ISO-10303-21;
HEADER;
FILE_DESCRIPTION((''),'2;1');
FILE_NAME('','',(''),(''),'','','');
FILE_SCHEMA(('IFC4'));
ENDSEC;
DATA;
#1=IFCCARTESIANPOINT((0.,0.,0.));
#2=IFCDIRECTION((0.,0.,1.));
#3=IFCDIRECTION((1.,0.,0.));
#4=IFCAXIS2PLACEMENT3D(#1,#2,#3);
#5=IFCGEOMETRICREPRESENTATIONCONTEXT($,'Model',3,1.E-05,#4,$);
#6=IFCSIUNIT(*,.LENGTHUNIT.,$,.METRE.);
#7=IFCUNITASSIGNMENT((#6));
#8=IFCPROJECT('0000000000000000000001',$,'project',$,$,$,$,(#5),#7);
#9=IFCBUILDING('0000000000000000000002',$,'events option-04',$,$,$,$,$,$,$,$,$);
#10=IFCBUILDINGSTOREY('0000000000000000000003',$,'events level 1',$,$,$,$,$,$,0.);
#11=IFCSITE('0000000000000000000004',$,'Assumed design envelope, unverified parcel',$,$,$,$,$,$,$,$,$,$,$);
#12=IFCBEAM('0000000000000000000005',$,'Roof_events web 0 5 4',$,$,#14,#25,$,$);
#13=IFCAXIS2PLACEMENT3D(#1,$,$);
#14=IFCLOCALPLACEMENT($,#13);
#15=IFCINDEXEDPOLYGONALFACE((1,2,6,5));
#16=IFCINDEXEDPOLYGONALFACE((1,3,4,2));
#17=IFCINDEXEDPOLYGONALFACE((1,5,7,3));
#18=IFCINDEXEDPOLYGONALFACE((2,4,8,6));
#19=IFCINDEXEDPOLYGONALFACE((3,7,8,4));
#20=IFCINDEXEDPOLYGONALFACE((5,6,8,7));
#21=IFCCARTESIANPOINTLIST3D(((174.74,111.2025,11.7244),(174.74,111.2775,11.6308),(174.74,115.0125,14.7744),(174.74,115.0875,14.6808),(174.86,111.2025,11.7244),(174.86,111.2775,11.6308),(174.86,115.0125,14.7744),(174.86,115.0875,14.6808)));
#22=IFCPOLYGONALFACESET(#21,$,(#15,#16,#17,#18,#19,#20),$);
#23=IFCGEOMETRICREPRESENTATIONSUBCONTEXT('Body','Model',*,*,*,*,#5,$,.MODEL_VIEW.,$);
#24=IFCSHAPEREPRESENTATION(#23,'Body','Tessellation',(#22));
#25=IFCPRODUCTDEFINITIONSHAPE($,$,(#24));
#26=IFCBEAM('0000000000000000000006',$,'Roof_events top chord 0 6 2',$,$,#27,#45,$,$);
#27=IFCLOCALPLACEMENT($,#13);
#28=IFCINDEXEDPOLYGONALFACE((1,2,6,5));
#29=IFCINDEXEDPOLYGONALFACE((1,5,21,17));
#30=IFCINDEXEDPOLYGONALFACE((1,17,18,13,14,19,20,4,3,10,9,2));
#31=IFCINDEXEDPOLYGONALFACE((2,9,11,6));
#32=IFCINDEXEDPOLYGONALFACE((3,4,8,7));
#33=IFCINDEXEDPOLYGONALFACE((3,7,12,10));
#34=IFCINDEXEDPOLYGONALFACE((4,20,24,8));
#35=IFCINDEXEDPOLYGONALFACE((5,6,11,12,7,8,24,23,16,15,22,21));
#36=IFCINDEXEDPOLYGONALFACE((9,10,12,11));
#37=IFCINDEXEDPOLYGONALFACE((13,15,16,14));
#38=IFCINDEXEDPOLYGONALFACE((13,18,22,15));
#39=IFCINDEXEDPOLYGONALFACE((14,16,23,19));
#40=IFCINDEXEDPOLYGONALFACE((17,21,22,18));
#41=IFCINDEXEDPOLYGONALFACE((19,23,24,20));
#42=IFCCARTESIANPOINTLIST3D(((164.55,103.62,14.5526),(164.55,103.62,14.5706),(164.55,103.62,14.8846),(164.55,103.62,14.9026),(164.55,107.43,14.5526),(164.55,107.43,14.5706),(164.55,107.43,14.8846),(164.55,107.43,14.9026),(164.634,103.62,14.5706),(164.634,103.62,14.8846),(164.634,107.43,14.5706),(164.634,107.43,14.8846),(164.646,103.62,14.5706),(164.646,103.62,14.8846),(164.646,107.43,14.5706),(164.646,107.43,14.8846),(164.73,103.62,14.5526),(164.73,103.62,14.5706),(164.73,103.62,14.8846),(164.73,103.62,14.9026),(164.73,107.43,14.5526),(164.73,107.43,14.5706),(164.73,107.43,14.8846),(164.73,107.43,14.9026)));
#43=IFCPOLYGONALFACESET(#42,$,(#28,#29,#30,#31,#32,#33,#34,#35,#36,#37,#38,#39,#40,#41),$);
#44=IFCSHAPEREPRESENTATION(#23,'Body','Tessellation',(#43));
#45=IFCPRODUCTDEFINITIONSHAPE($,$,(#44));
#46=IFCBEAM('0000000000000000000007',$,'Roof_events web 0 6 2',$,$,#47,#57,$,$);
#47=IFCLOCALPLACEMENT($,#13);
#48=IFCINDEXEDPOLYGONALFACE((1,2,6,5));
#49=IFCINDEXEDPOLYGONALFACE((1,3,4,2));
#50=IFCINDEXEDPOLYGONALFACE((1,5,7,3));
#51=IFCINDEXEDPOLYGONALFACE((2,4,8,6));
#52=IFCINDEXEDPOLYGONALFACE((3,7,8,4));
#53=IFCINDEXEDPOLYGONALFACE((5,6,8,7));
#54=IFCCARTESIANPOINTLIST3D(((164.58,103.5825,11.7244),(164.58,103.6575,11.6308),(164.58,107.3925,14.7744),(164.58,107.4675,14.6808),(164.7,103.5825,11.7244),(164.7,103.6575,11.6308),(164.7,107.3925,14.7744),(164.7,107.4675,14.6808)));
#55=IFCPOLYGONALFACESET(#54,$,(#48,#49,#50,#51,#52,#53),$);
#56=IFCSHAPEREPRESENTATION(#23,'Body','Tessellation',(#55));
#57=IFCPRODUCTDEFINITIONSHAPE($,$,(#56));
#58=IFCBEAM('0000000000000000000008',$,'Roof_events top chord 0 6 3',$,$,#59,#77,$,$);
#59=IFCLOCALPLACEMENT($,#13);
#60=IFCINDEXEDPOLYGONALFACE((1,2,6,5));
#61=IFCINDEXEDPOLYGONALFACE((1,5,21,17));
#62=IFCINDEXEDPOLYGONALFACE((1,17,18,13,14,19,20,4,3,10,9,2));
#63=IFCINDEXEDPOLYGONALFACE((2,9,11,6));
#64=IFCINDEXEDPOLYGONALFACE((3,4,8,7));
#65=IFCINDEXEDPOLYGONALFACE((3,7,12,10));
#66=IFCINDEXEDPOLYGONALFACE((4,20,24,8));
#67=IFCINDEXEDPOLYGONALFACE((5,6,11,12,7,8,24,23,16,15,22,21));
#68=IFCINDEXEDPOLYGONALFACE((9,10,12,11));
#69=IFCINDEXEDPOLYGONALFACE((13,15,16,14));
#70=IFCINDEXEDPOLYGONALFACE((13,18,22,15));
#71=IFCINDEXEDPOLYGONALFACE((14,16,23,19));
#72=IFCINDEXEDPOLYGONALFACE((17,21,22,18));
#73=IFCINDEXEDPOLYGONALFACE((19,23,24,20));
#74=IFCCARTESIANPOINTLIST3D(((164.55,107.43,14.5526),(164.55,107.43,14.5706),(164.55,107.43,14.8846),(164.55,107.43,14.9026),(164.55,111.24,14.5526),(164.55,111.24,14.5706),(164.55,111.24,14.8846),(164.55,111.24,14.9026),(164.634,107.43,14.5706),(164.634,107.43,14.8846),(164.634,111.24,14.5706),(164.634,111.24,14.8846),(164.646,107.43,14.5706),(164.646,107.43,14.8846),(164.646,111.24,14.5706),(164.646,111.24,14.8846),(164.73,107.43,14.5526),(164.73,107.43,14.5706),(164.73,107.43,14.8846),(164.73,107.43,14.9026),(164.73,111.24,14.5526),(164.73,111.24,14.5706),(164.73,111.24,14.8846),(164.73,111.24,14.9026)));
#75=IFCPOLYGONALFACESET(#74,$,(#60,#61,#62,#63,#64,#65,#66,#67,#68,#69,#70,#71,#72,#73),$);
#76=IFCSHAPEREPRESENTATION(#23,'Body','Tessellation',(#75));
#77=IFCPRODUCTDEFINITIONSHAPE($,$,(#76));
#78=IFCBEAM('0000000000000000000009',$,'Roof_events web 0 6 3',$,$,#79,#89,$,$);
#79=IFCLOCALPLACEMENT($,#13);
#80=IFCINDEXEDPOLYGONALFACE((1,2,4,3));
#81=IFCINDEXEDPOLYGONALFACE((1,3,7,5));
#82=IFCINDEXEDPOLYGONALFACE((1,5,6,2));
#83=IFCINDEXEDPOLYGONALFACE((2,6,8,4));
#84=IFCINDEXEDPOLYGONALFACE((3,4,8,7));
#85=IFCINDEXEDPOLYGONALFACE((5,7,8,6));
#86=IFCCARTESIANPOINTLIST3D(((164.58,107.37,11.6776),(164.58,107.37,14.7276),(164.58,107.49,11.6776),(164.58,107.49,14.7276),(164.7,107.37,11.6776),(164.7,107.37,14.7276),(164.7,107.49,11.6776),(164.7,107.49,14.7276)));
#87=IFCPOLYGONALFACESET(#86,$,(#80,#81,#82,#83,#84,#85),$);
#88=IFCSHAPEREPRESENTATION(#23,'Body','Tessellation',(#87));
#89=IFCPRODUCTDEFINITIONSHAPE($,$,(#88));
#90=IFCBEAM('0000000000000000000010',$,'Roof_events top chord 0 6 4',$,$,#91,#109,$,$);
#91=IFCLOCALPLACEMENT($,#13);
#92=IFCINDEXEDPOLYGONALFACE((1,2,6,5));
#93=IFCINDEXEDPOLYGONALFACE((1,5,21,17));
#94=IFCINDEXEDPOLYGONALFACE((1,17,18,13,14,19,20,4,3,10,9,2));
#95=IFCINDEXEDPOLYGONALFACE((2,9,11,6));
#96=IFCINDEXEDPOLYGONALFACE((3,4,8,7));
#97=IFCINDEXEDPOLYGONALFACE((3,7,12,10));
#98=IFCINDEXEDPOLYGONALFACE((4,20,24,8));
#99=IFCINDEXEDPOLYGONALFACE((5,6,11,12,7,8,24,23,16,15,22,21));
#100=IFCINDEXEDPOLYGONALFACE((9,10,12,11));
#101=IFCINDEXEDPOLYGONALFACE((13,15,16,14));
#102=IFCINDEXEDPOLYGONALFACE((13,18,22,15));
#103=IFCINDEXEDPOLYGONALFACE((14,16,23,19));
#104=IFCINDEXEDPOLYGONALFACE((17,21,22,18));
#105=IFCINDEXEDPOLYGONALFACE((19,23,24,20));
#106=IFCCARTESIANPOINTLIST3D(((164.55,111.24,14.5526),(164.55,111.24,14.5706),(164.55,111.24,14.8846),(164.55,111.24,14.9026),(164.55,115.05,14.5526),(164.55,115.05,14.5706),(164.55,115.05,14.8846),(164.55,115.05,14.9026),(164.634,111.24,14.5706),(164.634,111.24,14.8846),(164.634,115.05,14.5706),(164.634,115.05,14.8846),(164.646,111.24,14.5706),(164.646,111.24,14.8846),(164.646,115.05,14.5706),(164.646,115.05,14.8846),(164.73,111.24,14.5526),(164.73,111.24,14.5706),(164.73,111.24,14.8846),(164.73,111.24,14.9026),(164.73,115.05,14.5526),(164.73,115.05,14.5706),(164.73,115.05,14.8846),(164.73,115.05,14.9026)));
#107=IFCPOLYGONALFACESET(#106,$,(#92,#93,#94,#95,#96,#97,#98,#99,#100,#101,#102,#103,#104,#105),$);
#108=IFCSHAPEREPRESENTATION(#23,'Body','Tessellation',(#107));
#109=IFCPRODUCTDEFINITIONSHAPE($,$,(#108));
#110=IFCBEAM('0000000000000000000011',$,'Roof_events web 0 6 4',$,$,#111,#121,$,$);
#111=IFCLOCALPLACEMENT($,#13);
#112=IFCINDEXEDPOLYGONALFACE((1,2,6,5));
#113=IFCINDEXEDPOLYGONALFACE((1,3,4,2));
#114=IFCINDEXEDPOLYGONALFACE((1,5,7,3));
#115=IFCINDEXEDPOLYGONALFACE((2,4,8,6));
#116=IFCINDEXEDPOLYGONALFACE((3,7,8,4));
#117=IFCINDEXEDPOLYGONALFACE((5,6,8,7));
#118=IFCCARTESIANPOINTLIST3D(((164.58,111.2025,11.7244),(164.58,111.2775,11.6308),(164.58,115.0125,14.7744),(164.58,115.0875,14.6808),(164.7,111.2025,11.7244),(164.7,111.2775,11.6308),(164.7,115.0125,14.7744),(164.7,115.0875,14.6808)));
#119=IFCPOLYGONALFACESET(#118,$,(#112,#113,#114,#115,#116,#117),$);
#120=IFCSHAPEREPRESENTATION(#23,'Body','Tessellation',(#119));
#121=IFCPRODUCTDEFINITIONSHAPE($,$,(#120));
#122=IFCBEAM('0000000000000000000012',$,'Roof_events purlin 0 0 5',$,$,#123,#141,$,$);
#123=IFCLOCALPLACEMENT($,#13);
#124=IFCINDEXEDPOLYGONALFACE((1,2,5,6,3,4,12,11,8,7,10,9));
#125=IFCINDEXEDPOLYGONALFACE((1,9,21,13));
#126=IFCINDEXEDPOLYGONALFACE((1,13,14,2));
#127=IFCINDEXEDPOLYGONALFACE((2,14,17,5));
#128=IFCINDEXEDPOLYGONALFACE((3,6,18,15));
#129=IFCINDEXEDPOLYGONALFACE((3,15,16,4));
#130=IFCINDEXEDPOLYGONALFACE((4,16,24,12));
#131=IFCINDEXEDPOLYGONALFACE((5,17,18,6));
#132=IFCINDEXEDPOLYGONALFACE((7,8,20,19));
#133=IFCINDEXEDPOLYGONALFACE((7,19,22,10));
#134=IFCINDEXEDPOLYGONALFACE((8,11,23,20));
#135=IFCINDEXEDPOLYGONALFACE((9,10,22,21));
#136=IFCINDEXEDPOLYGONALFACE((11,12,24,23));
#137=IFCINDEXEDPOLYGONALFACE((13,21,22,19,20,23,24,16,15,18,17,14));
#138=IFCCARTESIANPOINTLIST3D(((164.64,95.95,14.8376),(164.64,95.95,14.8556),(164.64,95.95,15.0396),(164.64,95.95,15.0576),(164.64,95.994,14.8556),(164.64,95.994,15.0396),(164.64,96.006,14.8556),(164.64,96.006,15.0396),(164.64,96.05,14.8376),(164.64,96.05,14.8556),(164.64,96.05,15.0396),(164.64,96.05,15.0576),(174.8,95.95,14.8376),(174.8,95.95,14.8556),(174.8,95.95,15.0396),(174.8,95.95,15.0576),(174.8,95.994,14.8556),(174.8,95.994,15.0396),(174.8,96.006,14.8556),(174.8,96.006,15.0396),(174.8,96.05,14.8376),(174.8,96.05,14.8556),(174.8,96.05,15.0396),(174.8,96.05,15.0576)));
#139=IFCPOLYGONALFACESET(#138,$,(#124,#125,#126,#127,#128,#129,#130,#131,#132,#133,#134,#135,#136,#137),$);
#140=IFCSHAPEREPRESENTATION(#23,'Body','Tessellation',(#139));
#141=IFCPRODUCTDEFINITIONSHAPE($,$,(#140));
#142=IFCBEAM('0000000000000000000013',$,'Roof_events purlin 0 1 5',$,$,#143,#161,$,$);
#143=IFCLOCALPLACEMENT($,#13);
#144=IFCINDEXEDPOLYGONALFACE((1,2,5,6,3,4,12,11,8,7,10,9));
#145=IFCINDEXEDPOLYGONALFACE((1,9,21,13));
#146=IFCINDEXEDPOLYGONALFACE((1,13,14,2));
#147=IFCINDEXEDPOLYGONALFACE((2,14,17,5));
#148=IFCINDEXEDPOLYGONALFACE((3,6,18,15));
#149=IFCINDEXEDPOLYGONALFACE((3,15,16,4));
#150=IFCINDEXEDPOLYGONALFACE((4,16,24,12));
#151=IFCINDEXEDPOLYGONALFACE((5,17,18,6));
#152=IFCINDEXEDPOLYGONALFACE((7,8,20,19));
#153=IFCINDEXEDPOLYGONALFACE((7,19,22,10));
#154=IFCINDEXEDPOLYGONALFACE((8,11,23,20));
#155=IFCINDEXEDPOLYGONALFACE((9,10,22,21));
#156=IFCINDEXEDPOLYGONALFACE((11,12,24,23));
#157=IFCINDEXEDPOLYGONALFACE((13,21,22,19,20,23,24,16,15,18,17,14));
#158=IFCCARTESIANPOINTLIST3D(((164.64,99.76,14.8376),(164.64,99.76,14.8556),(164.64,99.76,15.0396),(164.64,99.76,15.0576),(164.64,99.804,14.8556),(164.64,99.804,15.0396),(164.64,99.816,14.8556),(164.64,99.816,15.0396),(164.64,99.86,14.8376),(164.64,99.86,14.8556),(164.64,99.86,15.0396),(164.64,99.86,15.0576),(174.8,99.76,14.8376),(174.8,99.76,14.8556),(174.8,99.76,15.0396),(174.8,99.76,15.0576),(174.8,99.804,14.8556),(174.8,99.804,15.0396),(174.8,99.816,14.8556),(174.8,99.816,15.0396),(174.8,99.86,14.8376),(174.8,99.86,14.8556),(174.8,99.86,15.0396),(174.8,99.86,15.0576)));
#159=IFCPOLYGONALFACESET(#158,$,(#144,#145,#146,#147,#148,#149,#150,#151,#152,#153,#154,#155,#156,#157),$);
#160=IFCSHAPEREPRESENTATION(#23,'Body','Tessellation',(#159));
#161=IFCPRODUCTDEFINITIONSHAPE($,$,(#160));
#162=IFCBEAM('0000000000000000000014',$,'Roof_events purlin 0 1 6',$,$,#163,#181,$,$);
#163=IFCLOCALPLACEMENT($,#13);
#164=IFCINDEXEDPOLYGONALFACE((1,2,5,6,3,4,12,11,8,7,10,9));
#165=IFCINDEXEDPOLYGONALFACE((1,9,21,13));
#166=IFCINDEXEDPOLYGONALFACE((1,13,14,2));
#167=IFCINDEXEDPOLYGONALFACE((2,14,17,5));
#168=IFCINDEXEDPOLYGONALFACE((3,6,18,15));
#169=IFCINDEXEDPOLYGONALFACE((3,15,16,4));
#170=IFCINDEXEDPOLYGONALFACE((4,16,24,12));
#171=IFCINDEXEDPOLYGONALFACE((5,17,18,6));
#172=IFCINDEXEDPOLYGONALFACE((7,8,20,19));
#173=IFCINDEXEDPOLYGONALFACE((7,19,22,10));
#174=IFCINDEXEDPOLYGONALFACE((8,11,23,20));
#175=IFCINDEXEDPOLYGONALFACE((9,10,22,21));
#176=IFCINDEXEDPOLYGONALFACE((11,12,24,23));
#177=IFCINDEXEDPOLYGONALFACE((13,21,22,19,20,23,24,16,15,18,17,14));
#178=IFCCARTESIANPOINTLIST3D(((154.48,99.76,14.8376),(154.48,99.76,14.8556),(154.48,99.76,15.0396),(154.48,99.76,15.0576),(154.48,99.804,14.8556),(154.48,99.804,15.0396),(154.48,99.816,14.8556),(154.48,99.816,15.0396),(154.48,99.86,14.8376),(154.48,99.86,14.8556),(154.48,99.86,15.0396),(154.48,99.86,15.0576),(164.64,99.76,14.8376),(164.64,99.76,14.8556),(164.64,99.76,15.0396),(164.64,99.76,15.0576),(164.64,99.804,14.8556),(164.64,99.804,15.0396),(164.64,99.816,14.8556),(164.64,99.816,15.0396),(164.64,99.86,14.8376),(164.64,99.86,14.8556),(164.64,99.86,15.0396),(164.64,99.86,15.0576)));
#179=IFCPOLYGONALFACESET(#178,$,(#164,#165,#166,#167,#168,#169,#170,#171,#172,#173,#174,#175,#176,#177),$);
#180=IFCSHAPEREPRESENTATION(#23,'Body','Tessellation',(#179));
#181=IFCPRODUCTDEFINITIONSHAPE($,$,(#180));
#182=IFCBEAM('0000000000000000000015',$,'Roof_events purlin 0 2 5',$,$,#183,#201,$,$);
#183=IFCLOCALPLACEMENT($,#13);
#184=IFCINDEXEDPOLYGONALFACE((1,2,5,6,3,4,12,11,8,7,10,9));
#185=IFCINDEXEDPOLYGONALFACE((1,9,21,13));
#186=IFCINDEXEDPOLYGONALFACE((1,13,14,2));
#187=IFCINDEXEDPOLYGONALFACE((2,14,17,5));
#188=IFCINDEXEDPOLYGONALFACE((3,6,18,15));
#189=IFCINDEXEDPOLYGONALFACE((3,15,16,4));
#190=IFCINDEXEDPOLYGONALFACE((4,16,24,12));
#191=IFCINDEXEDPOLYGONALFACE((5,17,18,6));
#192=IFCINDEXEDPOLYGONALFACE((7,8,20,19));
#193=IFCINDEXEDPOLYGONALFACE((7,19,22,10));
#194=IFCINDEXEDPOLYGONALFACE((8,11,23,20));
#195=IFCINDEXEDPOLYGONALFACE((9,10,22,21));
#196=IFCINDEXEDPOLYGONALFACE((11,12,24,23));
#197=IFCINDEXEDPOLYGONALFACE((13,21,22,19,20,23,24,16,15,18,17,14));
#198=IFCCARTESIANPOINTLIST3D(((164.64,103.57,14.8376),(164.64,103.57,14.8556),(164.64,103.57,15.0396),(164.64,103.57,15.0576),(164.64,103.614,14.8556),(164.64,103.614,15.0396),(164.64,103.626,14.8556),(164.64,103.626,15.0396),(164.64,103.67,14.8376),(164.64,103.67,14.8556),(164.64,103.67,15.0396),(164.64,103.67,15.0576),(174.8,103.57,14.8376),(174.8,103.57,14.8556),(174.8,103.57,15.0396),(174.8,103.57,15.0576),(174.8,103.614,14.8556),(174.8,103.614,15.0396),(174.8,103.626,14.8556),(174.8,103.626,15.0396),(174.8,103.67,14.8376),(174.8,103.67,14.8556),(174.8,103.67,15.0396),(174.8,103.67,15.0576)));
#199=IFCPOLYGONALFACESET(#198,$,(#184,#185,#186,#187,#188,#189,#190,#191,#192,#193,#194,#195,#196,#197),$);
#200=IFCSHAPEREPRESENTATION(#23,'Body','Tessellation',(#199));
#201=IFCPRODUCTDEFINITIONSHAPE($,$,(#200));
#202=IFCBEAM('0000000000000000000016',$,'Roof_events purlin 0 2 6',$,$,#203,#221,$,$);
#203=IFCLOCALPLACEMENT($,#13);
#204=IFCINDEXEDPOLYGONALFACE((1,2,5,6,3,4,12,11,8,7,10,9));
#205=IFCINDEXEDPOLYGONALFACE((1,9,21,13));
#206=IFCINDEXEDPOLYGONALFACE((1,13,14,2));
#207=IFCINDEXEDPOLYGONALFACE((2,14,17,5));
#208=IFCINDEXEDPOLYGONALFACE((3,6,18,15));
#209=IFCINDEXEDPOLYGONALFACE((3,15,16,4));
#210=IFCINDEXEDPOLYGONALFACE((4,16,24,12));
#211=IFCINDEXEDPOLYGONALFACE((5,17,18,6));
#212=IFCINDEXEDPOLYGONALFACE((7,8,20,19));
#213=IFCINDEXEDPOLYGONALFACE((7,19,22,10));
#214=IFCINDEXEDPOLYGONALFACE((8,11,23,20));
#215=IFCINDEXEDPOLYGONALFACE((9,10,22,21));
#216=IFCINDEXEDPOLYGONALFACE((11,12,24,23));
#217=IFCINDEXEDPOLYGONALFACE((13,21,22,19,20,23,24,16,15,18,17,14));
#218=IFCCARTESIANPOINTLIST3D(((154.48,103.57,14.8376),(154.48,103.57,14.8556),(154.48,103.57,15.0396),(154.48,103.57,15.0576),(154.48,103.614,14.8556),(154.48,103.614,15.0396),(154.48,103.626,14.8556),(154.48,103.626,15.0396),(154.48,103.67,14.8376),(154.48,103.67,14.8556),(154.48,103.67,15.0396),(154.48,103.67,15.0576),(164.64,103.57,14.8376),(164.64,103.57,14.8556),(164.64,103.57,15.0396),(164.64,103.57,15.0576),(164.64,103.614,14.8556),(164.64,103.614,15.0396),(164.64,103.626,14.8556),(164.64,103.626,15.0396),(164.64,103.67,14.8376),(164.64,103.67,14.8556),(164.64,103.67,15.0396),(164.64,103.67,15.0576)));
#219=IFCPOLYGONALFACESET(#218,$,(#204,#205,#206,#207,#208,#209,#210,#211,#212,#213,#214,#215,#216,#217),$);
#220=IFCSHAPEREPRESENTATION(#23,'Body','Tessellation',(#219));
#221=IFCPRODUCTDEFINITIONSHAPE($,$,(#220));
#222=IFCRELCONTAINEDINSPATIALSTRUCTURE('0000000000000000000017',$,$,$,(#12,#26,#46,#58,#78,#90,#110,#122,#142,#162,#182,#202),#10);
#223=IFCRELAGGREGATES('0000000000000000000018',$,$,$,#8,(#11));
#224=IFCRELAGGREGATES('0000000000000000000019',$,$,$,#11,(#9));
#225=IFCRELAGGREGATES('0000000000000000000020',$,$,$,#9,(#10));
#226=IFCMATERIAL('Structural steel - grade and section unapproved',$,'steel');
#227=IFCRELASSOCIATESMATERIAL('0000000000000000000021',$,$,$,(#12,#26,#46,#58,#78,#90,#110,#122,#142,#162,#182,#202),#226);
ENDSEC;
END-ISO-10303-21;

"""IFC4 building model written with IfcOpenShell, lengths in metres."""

from ifc_helpers import new_model, si_unit, frame, origin_with_axes, place, context, subcontext, project, spatial, rectangle, i_section, extrude, material, element, save


model = new_model("IFC4")

# Units and contexts
model_context = context("Model", 3, precision=1e-05, world=origin_with_axes())
body_context = subcontext(model_context, "Body", "Model", "MODEL_VIEW")
ifc_project = project(units=[si_unit("LENGTHUNIT", "METRE")], contexts=[model_context])

# Site, building, storey
site = spatial("IfcSite", under=ifc_project, Name="Assumed design envelope, unverified parcel")
building = spatial("IfcBuilding", under=site, Name="events option-04")
storey = spatial("IfcBuildingStorey", under=building, Name="events level 1", Elevation=0.0)

# Shared definitions
ifc_material_1 = material(Name="Structural steel - grade and section unapproved", Category="steel")

# Beams
beam_1_placement = place(None, frame((174.8, 111.24, 11.6776), z_axis=(0.0, 0.780669, 0.624944), x_axis=(-1.0, 0.0, 0.0)))
element("IfcBeam", 1, at=beam_1_placement, inside=storey, material=ifc_material_1, Name="Roof_events web 0 5 4", context=body_context, shape_type="SweptSolid", body=[
    extrude(rectangle(XDim=0.12, YDim=0.12), origin_with_axes(), (0.0, 0.0, 1.0), 4.8804),
])
beam_2_placement = place(None, frame((164.64, 103.62, 14.7276), z_axis=(0.0, 1.0, 0.0), x_axis=(-1.0, 0.0, 0.0)))
element("IfcBeam", 2, at=beam_2_placement, inside=storey, material=ifc_material_1, Name="Roof_events top chord 0 6 2", context=body_context, shape_type="SweptSolid", body=[
    extrude(i_section(OverallWidth=0.18, OverallDepth=0.35, WebThickness=0.012, FlangeThickness=0.018, FilletRadius=0.0), origin_with_axes(), (0.0, 0.0, 1.0), 3.81),
])
beam_3_placement = place(None, frame((164.64, 103.62, 11.6776), z_axis=(0.0, 0.780669, 0.624945), x_axis=(-1.0, 0.0, 0.0)))
element("IfcBeam", 3, at=beam_3_placement, inside=storey, material=ifc_material_1, Name="Roof_events web 0 6 2", context=body_context, shape_type="SweptSolid", body=[
    extrude(rectangle(XDim=0.12, YDim=0.12), origin_with_axes(), (0.0, 0.0, 1.0), 4.8804),
])
beam_4_placement = place(None, frame((164.64, 107.43, 14.7276), z_axis=(0.0, 1.0, 0.0), x_axis=(-1.0, 0.0, 0.0)))
element("IfcBeam", 4, at=beam_4_placement, inside=storey, material=ifc_material_1, Name="Roof_events top chord 0 6 3", context=body_context, shape_type="SweptSolid", body=[
    extrude(i_section(OverallWidth=0.18, OverallDepth=0.35, WebThickness=0.012, FlangeThickness=0.018, FilletRadius=0.0), origin_with_axes(), (0.0, 0.0, 1.0), 3.81),
])
beam_5_placement = place(None, frame((164.64, 107.43, 11.6776), z_axis=(0.0, 0.0, 1.0), x_axis=(-1.0, 0.0, 0.0)))
element("IfcBeam", 5, at=beam_5_placement, inside=storey, material=ifc_material_1, Name="Roof_events web 0 6 3", context=body_context, shape_type="SweptSolid", body=[
    extrude(rectangle(XDim=0.12, YDim=0.12), origin_with_axes(), (0.0, 0.0, 1.0), 3.05),
])
beam_6_placement = place(None, frame((164.64, 111.24, 14.7276), z_axis=(0.0, 1.0, 0.0), x_axis=(-1.0, 0.0, 0.0)))
element("IfcBeam", 6, at=beam_6_placement, inside=storey, material=ifc_material_1, Name="Roof_events top chord 0 6 4", context=body_context, shape_type="SweptSolid", body=[
    extrude(i_section(OverallWidth=0.18, OverallDepth=0.35, WebThickness=0.012, FlangeThickness=0.018, FilletRadius=0.0), origin_with_axes(), (0.0, 0.0, 1.0), 3.81),
])
beam_7_placement = place(None, frame((164.64, 111.24, 11.6776), z_axis=(0.0, 0.780669, 0.624944), x_axis=(-1.0, 0.0, 0.0)))
element("IfcBeam", 7, at=beam_7_placement, inside=storey, material=ifc_material_1, Name="Roof_events web 0 6 4", context=body_context, shape_type="SweptSolid", body=[
    extrude(rectangle(XDim=0.12, YDim=0.12), origin_with_axes(), (0.0, 0.0, 1.0), 4.8804),
])
for number, where, z_axis, x_axis, name in (
    (8, (174.8, 96.0, 14.9476), (-1.0, 0.0, 0.0), (0.0, -1.0, 0.0), "Roof_events purlin 0 0 5"),
    (9, (174.8, 99.81, 14.9476), (-1.0, 0.0, 0.0), (0.0, -1.0, 0.0), "Roof_events purlin 0 1 5"),
    (10, (164.64, 99.81, 14.9476), (-1.0, 0.0, 0.0), (0.0, -1.0, 0.0), "Roof_events purlin 0 1 6"),
    (11, (174.8, 103.62, 14.9476), (-1.0, 0.0, 0.0), (0.0, -1.0, 0.0), "Roof_events purlin 0 2 5"),
    (12, (164.64, 103.62, 14.9476), (-1.0, 0.0, 0.0), (0.0, -1.0, 0.0), "Roof_events purlin 0 2 6"),
):
    element("IfcBeam", number, at=place(None, frame(where, z_axis=z_axis, x_axis=x_axis)), inside=storey, material=ifc_material_1, Name=name, context=body_context, shape_type="SweptSolid", body=[
        extrude(i_section(OverallWidth=0.1, OverallDepth=0.22, WebThickness=0.012, FlangeThickness=0.018, FilletRadius=0.0), origin_with_axes(), (0.0, 0.0, 1.0), 10.16),
    ])

save(model, "model.ifc")
